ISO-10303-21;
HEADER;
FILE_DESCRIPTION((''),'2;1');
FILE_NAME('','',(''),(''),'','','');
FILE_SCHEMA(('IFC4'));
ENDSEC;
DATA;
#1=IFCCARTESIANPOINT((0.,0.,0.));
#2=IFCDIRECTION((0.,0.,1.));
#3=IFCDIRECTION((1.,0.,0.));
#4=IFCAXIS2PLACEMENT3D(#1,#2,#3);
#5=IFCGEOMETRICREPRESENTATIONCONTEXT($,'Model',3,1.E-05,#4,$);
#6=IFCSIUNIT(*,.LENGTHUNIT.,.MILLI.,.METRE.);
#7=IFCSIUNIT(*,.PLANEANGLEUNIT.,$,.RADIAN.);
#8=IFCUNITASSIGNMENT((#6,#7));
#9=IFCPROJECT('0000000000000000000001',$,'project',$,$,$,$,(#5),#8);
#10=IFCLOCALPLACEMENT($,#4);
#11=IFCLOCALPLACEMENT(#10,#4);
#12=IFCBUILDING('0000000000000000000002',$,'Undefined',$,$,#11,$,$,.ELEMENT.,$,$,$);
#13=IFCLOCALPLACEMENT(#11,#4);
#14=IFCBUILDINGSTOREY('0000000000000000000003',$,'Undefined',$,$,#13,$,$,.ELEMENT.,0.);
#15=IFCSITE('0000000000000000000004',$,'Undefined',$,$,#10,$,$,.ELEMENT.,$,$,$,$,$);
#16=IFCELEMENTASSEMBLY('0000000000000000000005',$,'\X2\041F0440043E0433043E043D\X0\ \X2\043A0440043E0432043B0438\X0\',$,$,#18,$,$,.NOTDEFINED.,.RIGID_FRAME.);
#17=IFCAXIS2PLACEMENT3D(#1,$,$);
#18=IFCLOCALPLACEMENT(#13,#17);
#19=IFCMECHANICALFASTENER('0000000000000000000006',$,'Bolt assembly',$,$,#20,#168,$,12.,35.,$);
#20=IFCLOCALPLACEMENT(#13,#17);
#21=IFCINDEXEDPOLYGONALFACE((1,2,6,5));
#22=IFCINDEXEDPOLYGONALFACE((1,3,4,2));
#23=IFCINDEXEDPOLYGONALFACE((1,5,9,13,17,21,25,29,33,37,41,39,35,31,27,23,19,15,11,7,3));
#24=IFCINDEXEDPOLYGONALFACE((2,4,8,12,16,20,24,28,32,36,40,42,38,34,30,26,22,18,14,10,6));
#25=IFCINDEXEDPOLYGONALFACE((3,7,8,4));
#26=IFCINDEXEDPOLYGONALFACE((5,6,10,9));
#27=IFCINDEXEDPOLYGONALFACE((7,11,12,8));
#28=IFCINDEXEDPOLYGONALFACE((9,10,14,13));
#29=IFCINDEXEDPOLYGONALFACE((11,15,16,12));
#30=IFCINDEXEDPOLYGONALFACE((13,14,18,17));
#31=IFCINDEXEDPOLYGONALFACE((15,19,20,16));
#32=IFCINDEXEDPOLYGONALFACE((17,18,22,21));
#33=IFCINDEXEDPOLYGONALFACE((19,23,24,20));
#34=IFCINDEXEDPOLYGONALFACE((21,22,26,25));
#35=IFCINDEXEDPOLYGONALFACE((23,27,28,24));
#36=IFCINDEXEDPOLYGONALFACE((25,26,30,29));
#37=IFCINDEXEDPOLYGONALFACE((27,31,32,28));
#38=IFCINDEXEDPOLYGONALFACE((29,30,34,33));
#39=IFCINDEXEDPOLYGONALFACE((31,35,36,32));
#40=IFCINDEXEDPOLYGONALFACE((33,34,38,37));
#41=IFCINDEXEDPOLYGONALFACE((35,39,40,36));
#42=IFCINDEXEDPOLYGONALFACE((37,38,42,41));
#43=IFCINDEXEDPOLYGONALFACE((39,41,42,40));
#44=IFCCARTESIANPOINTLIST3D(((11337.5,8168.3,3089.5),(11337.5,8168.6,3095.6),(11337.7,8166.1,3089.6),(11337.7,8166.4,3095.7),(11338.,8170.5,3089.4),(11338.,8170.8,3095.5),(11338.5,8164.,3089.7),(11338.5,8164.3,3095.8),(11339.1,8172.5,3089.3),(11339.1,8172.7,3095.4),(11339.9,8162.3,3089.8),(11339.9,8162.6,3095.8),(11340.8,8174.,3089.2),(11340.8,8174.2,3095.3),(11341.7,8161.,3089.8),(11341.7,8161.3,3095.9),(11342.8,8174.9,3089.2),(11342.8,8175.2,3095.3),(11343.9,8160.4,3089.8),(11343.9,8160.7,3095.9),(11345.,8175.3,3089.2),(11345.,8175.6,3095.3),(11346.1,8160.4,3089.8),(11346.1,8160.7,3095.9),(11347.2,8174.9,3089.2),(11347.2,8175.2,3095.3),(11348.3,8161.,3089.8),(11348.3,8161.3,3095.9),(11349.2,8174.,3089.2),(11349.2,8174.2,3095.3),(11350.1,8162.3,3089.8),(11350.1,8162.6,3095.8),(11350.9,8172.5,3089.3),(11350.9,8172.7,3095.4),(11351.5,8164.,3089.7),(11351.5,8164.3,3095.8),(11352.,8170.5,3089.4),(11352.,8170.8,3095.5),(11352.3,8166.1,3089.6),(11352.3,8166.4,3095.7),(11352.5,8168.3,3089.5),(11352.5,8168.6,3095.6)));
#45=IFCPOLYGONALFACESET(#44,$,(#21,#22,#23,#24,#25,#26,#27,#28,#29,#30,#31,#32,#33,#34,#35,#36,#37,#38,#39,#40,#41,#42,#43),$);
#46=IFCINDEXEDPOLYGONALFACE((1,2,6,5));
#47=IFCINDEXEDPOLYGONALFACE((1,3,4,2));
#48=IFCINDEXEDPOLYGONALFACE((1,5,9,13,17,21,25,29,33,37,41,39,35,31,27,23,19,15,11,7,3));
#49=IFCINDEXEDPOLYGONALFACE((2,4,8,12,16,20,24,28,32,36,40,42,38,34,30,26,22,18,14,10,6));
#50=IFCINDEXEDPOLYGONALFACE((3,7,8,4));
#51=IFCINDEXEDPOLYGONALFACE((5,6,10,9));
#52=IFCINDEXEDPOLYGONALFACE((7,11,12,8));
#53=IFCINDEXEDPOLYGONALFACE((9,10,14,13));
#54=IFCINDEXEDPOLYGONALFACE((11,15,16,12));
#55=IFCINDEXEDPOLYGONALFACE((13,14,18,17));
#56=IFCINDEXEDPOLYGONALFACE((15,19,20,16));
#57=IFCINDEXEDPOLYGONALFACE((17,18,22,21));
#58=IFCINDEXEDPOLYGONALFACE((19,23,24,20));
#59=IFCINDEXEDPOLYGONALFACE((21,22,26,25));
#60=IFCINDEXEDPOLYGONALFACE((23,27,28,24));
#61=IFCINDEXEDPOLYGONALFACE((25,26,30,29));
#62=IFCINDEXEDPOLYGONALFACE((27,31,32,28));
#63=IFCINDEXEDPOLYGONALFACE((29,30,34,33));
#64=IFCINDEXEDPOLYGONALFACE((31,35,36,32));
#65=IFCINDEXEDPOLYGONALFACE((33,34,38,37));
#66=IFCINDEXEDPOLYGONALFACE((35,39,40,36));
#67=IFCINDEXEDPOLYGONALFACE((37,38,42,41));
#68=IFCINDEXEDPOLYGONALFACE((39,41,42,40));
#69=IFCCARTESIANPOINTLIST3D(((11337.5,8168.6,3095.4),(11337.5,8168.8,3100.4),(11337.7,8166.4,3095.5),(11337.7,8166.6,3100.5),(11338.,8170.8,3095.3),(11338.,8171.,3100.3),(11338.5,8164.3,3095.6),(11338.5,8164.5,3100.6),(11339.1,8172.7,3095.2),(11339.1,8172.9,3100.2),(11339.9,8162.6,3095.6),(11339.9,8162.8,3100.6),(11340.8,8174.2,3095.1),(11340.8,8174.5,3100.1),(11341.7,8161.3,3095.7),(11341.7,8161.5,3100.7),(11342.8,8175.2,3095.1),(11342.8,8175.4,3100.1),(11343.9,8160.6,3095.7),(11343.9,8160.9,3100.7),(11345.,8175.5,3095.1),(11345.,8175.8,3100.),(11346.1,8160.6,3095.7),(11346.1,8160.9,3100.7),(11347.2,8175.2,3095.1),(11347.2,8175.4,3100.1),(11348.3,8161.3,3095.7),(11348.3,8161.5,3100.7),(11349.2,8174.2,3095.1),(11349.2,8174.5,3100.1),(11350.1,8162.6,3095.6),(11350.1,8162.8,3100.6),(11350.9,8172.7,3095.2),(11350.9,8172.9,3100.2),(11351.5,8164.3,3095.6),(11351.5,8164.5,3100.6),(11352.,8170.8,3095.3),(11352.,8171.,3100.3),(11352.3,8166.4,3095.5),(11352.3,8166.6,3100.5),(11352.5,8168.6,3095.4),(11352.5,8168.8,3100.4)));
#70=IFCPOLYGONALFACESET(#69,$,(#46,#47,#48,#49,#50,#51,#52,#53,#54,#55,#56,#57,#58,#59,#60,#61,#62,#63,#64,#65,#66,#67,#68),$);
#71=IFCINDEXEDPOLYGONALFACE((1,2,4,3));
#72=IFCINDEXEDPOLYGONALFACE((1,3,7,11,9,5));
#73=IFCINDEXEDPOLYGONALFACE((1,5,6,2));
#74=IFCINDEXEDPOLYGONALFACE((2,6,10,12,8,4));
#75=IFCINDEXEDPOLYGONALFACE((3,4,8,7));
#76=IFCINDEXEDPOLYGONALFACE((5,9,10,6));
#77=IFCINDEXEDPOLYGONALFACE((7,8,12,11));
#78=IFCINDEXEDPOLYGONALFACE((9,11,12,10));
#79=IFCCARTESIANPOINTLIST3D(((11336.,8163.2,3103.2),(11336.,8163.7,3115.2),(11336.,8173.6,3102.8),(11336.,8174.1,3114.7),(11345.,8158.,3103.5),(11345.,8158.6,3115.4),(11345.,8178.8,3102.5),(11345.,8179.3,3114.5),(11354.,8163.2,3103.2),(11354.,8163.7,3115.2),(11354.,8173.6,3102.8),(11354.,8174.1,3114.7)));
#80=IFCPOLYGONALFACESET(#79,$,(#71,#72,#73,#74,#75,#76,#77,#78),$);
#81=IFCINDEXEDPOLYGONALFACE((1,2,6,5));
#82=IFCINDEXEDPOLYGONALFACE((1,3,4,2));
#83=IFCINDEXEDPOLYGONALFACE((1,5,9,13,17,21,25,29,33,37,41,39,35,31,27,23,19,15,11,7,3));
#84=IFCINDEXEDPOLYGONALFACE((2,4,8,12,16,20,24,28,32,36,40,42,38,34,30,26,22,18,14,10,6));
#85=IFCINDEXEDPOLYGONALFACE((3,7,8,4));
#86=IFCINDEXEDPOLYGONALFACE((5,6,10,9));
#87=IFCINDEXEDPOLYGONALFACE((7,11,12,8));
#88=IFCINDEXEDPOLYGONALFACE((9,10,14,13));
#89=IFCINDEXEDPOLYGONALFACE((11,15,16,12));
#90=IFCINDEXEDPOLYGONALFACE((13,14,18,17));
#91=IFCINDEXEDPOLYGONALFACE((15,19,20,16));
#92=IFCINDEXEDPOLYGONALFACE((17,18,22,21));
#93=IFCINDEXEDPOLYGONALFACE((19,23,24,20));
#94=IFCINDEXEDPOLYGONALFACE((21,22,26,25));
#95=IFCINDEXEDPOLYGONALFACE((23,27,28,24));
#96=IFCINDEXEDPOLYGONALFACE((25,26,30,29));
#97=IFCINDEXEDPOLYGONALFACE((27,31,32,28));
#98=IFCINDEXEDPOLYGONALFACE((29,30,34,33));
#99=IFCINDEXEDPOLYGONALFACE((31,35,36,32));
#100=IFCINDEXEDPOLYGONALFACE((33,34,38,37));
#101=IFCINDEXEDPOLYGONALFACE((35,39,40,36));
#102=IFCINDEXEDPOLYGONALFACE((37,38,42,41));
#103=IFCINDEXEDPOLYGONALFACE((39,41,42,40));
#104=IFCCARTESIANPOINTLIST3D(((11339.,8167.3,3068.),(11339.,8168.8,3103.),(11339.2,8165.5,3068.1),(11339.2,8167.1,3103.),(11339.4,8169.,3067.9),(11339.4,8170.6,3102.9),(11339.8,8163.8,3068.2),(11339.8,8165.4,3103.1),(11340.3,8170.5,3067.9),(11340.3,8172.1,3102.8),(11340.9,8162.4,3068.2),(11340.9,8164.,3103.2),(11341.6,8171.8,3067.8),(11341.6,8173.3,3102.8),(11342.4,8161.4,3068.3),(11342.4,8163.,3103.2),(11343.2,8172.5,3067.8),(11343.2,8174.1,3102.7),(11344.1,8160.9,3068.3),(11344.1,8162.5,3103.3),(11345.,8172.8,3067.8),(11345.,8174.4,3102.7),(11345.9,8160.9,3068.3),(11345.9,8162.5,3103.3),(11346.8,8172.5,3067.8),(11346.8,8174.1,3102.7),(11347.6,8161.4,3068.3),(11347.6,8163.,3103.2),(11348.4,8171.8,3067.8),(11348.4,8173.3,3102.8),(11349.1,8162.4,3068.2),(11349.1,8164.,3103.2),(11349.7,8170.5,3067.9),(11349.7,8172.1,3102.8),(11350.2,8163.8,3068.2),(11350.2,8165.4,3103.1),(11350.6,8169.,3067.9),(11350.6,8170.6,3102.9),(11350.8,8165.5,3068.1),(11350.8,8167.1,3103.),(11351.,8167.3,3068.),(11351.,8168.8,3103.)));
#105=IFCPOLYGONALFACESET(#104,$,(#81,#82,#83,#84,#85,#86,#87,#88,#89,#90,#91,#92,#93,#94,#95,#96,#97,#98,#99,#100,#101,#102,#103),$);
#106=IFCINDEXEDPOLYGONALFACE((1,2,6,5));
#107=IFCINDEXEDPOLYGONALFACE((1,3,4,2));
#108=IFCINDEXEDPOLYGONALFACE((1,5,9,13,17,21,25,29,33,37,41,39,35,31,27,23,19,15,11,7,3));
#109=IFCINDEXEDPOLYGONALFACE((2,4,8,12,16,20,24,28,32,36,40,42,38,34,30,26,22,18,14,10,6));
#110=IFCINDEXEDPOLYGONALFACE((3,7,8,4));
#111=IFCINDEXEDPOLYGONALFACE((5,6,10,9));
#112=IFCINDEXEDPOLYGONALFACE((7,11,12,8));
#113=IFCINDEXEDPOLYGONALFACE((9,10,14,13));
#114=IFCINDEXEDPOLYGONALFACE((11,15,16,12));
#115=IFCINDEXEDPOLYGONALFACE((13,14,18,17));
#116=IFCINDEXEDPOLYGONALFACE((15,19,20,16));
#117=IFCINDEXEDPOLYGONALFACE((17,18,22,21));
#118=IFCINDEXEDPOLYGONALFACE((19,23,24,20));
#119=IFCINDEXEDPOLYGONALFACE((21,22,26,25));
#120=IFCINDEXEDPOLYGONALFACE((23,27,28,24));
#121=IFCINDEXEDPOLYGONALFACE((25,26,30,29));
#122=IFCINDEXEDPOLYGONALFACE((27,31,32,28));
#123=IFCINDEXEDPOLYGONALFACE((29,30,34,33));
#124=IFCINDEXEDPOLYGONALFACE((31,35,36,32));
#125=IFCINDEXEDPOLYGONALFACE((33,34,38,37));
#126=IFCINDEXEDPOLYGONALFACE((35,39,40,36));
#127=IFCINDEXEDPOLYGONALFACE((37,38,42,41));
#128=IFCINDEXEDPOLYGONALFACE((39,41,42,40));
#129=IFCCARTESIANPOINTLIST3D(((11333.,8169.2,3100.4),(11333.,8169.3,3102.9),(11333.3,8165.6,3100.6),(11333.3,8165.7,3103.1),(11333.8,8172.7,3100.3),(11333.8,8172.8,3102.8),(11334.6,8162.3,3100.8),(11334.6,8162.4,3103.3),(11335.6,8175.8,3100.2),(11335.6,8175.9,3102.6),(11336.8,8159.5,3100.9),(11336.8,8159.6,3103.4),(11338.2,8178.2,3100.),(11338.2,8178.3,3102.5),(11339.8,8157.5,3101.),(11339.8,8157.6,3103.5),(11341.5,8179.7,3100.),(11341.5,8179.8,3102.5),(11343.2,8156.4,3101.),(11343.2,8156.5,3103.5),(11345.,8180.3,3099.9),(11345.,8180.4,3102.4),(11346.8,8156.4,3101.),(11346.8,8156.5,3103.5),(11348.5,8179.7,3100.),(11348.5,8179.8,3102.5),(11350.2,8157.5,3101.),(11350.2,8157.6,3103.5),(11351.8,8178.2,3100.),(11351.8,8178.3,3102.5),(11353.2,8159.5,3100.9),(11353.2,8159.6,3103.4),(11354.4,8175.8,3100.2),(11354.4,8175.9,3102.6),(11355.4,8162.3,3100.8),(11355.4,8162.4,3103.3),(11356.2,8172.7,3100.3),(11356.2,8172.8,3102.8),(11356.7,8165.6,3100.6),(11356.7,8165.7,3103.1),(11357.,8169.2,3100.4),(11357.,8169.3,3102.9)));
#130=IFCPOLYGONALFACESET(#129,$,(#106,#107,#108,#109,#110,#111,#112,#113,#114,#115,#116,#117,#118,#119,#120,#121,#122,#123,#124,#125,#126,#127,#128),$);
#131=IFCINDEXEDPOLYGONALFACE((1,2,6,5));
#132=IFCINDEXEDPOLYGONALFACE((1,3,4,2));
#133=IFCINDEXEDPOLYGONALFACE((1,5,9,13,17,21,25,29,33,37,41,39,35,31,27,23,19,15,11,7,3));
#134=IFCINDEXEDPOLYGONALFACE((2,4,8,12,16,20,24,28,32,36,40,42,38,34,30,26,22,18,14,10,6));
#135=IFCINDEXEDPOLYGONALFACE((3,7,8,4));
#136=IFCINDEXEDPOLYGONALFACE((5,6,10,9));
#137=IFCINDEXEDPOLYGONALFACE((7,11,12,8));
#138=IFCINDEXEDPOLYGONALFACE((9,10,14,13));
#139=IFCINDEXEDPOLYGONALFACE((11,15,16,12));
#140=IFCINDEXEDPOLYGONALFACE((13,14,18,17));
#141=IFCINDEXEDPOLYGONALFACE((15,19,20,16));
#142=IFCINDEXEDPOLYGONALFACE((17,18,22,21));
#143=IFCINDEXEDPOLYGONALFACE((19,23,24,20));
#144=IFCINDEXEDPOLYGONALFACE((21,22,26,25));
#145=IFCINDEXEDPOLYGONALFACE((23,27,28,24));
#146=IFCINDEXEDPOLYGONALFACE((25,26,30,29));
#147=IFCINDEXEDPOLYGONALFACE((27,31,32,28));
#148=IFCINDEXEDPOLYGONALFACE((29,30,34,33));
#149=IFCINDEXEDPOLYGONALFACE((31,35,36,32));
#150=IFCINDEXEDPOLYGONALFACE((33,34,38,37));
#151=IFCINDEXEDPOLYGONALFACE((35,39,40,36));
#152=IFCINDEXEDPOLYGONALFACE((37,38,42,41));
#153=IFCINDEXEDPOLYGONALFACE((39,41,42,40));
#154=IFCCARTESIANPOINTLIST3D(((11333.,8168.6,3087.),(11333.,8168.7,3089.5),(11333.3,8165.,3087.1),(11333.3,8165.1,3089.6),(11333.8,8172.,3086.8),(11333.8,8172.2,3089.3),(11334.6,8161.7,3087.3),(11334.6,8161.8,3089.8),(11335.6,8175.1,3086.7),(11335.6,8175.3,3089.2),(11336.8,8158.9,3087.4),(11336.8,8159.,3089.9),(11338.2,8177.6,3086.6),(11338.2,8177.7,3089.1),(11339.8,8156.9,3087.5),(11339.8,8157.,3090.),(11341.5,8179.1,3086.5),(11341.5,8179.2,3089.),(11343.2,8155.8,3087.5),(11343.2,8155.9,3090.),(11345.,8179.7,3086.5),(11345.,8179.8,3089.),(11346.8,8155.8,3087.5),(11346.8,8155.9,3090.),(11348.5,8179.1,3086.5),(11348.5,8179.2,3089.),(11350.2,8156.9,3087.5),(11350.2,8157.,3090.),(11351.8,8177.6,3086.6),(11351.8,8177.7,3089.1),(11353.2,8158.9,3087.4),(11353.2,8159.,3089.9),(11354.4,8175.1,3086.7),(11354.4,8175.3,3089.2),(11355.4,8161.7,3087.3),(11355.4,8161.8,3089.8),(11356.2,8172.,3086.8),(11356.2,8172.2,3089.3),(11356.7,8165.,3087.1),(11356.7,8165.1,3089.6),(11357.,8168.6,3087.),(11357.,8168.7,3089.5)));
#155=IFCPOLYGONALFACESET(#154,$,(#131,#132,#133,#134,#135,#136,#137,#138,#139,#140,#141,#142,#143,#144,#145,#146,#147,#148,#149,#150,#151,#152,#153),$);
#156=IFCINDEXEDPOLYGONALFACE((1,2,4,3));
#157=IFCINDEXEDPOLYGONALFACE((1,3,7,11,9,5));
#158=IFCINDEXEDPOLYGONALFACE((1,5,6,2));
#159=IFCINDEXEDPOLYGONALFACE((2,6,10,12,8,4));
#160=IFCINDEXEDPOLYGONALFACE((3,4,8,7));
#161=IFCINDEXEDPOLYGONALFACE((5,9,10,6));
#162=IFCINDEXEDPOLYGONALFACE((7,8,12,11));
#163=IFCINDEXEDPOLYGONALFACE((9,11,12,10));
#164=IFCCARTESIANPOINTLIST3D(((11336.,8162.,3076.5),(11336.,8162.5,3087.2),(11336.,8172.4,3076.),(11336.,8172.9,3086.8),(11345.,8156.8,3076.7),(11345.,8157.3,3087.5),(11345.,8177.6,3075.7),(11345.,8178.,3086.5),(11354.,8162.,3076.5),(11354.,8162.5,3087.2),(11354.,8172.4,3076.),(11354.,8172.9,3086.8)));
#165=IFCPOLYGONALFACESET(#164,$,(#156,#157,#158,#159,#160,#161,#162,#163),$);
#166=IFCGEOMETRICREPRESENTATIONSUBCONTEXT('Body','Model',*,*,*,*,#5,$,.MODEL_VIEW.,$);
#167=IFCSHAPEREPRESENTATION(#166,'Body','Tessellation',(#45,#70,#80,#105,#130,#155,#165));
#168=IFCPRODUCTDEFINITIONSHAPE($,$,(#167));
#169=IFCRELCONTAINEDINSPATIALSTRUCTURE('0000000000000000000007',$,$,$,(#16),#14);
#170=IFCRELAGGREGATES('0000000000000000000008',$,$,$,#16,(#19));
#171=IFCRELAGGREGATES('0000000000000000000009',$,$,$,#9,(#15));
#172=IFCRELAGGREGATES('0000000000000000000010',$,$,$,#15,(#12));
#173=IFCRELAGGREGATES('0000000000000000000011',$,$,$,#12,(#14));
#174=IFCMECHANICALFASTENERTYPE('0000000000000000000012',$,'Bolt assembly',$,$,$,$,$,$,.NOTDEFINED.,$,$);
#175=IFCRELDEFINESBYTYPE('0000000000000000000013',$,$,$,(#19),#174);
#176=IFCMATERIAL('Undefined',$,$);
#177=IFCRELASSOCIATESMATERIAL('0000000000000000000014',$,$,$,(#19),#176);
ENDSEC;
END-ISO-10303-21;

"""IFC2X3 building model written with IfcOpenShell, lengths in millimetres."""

from ifc_helpers import new_model, si_unit, frame, origin_with_axes, origin_2d_with_axis, place, context, subcontext, project, spatial, polyline, circle, outline, extrude, source, transform, mapped, material, type_object, element, aggregate, save


model = new_model("IFC2X3")

# Units and contexts
model_context = context("Model", 3, precision=1e-05, world=origin_with_axes())
body_context = subcontext(model_context, "Body", "Model", "MODEL_VIEW")
ifc_project = project(units=[si_unit("LENGTHUNIT", "METRE", prefix="MILLI"), si_unit("PLANEANGLEUNIT", "RADIAN")], contexts=[model_context])

# Site, building, storey
site_placement = place(None, origin_with_axes())
site = spatial("IfcSite", under=ifc_project, at=site_placement, Name="Undefined", CompositionType="ELEMENT")
building_placement = place(site_placement, origin_with_axes())
building = spatial("IfcBuilding", under=site, at=building_placement, Name="Undefined", CompositionType="ELEMENT")
storey_placement = place(building_placement, origin_with_axes())
storey = spatial("IfcBuildingStorey", under=building, at=storey_placement, Name="Undefined", CompositionType="ELEMENT", Elevation=0.0)

# Element assembly
assembly_1_placement = place(storey_placement, origin_with_axes())
assembly_1 = element("IfcElementAssembly", 1, at=assembly_1_placement, inside=storey, Name="Прогон кровли", AssemblyPlace="NOTDEFINED", PredefinedType="RIGID_FRAME")

# Mechanical fastener
ifc_material_1 = material(Name="Undefined")
mechanical_fastener_type = type_object("IfcMechanicalFastenerType", Name="Bolt assembly")
shared_shape_1 = source(origin_with_axes(), body_context, "Body", "SweptSolid", [
    extrude(circle(Radius=7.5, at=origin_2d_with_axis()), frame((0.0, -0.1, 0.0), z_axis=(0.0, 1.0, 0.0), x_axis=(1.0, 0.0, 0.0)), (0.0, 0.0, 1.0), 6.1),
    extrude(circle(Radius=7.5, at=origin_2d_with_axis()), frame((0.0, -4.9, 0.0), z_axis=(0.0, 1.0, 0.0), x_axis=(1.0, 0.0, 0.0)), (0.0, 0.0, 1.0), 5.0),
    extrude(outline(polyline([(10.4, 0.0), (5.2, 9.0), (-5.2, 9.0), (-10.4, 0.0), (-5.2, -9.0), (5.2, -9.0), (10.4, 0.0)])), frame((0.0, -19.5, 0.0), z_axis=(0.0, 1.0, 0.0), x_axis=(1.0, 0.0, 0.0)), (0.0, 0.0, 1.0), 12.0),
    extrude(circle(Radius=6.0, at=origin_2d_with_axis()), frame((0.0, -7.5, 0.0), z_axis=(0.0, 1.0, 0.0), x_axis=(1.0, 0.0, 0.0)), (0.0, 0.0, 1.0), 35.0),
    extrude(circle(Radius=12.0, at=origin_2d_with_axis()), frame((0.0, -7.5, 0.0), z_axis=(0.0, 1.0, 0.0), x_axis=(1.0, 0.0, 0.0)), (0.0, 0.0, 1.0), 2.5),
    extrude(circle(Radius=12.0, at=origin_2d_with_axis()), frame((0.0, 6.0, 0.0), z_axis=(0.0, 1.0, 0.0), x_axis=(1.0, 0.0, 0.0)), (0.0, 0.0, 1.0), 2.5),
    extrude(outline(polyline([(10.4, 0.0), (5.2, 9.0), (-5.2, 9.0), (-10.4, 0.0), (-5.2, -9.0), (5.2, -9.0), (10.4, 0.0)])), frame((0.0, 8.5, 0.0), z_axis=(0.0, 1.0, 0.0), x_axis=(1.0, 0.0, 0.0)), (0.0, 0.0, 1.0), 10.8),
])
mechanical_fastener_1_placement = place(assembly_1_placement, frame((11345.0, 8168.1, 3095.5), z_axis=(-1.0, 0.0, 0.0), x_axis=(0.0, 0.998969, -0.045408)))
mechanical_fastener_1 = element("IfcMechanicalFastener", 2, at=mechanical_fastener_1_placement, type_object=mechanical_fastener_type, material=ifc_material_1, Name="Bolt assembly", NominalDiameter=12.0, NominalLength=35.0, context=body_context, shape_type="MappedRepresentation", body=[
    mapped(shared_shape_1, transform((0.0, 0.0, 0.0))),
])
aggregate(assembly_1, [mechanical_fastener_1])

save(model, "model.ifc")
